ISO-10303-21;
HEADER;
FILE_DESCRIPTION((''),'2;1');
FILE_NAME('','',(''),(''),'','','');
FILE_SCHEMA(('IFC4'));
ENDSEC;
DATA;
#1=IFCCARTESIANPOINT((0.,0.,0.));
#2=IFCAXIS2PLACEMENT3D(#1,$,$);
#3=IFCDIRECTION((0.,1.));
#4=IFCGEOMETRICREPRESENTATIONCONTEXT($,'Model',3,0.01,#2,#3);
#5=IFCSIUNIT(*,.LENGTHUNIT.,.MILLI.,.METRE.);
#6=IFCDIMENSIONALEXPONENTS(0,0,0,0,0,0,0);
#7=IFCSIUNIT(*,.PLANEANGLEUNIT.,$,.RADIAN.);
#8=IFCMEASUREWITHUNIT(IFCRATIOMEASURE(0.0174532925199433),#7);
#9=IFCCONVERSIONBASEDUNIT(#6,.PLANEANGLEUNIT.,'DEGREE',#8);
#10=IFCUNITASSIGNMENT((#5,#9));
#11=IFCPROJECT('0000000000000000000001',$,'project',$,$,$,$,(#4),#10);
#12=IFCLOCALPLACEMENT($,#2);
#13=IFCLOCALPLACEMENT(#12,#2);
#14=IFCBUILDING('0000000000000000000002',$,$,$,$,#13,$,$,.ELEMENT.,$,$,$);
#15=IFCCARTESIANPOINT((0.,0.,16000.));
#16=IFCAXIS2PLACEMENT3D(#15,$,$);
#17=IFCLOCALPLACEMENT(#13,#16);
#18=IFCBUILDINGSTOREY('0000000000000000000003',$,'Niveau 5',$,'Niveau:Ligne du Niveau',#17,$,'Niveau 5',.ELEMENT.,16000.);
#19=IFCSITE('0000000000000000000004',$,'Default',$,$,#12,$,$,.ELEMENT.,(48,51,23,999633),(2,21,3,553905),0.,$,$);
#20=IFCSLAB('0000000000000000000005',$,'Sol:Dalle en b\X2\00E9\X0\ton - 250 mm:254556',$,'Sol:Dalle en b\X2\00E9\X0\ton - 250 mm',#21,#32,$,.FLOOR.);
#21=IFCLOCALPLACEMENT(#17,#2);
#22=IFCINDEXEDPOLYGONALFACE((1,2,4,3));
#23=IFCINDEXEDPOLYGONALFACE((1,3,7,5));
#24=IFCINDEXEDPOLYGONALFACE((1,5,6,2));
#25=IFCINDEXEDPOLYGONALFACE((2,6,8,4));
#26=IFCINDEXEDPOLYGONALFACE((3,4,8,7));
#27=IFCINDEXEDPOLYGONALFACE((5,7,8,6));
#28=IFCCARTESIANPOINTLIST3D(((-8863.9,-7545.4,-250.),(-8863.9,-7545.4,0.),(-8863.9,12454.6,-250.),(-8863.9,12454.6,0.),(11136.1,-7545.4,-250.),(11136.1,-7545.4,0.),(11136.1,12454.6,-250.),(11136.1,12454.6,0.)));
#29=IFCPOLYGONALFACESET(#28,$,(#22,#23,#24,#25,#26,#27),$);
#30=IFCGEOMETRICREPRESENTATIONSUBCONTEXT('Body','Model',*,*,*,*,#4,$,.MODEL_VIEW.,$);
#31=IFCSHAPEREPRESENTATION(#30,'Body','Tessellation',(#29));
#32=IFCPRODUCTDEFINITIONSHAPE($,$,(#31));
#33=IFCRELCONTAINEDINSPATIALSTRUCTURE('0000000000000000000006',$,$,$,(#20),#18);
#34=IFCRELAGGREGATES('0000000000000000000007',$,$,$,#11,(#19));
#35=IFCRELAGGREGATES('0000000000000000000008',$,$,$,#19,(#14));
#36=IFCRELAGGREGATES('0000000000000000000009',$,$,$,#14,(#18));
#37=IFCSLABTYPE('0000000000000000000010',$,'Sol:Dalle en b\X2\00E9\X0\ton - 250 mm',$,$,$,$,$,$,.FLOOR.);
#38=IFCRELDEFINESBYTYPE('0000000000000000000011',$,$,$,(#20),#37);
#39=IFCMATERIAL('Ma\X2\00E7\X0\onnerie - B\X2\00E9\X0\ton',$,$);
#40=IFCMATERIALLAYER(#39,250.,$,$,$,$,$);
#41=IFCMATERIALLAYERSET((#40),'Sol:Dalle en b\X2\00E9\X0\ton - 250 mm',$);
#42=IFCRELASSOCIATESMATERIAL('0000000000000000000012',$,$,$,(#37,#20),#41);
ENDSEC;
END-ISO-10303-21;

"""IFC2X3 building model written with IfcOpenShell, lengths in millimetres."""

from ifc_helpers import new_model, entity, si_unit, converted_unit, direction, frame, origin, origin_2d_with_axis, place, context, subcontext, project, spatial, rectangle, extrude, material, layer, layer_set, layer_usage, type_object, element, save


model = new_model("IFC2X3")

# Units and contexts
model_context = context("Model", 3, precision=0.01, world=origin(), true_north=direction((0.0, 1.0)))
body_context = subcontext(model_context, "Body", "Model", "MODEL_VIEW")
ifc_project = project(units=[si_unit("LENGTHUNIT", "METRE", prefix="MILLI"), converted_unit("PLANEANGLEUNIT", "DEGREE", entity("IfcRatioMeasure", 0.0174532925199433), si_unit("PLANEANGLEUNIT", "RADIAN"), dimensions=[0, 0, 0, 0, 0, 0, 0])], contexts=[model_context])

# Site, building, storey
site_placement = place(None, origin())
site = spatial("IfcSite", under=ifc_project, at=site_placement, Name="Default", CompositionType="ELEMENT", RefLatitude=(48, 51, 23, 999633), RefLongitude=(2, 21, 3, 553905), RefElevation=0.0)
building_placement = place(site_placement, origin())
building = spatial("IfcBuilding", under=site, at=building_placement, CompositionType="ELEMENT")
storey_placement = place(building_placement, frame((0.0, 0.0, 16000.0)))
storey = spatial("IfcBuildingStorey", under=building, at=storey_placement, Name="Niveau 5", ObjectType="Niveau:Ligne du Niveau", LongName="Niveau 5", CompositionType="ELEMENT", Elevation=16000.0)

# Slab
ifc_material = material(Name="Maçonnerie - Béton")
ifc_layer = layer(ifc_material, 250.0)
ifc_layer_set = layer_set([ifc_layer], Name="Sol:Dalle en béton - 250 mm")
ifc_layer_usage = layer_usage(ifc_layer_set, "AXIS3", "POSITIVE", 0.0)
slab_type = type_object("IfcSlabType", Name="Sol:Dalle en béton - 250 mm", PredefinedType="FLOOR", material=ifc_layer_set)
slab_placement = place(storey_placement, origin())
element("IfcSlab", 1, at=slab_placement, inside=storey, type_object=slab_type, material=ifc_layer_usage, Name="Sol:Dalle en béton - 250 mm:254556", ObjectType="Sol:Dalle en béton - 250 mm", PredefinedType="FLOOR", context=body_context, shape_type="SweptSolid", body=[
    extrude(rectangle(XDim=20000.0, YDim=20000.0, at=origin_2d_with_axis()), frame((1136.1, 2454.6, 0.0), z_axis=(0.0, 0.0, -1.0), x_axis=(0.0, 1.0, 0.0)), (0.0, 0.0, 1.0), 250.0),
])

save(model, "model.ifc")
